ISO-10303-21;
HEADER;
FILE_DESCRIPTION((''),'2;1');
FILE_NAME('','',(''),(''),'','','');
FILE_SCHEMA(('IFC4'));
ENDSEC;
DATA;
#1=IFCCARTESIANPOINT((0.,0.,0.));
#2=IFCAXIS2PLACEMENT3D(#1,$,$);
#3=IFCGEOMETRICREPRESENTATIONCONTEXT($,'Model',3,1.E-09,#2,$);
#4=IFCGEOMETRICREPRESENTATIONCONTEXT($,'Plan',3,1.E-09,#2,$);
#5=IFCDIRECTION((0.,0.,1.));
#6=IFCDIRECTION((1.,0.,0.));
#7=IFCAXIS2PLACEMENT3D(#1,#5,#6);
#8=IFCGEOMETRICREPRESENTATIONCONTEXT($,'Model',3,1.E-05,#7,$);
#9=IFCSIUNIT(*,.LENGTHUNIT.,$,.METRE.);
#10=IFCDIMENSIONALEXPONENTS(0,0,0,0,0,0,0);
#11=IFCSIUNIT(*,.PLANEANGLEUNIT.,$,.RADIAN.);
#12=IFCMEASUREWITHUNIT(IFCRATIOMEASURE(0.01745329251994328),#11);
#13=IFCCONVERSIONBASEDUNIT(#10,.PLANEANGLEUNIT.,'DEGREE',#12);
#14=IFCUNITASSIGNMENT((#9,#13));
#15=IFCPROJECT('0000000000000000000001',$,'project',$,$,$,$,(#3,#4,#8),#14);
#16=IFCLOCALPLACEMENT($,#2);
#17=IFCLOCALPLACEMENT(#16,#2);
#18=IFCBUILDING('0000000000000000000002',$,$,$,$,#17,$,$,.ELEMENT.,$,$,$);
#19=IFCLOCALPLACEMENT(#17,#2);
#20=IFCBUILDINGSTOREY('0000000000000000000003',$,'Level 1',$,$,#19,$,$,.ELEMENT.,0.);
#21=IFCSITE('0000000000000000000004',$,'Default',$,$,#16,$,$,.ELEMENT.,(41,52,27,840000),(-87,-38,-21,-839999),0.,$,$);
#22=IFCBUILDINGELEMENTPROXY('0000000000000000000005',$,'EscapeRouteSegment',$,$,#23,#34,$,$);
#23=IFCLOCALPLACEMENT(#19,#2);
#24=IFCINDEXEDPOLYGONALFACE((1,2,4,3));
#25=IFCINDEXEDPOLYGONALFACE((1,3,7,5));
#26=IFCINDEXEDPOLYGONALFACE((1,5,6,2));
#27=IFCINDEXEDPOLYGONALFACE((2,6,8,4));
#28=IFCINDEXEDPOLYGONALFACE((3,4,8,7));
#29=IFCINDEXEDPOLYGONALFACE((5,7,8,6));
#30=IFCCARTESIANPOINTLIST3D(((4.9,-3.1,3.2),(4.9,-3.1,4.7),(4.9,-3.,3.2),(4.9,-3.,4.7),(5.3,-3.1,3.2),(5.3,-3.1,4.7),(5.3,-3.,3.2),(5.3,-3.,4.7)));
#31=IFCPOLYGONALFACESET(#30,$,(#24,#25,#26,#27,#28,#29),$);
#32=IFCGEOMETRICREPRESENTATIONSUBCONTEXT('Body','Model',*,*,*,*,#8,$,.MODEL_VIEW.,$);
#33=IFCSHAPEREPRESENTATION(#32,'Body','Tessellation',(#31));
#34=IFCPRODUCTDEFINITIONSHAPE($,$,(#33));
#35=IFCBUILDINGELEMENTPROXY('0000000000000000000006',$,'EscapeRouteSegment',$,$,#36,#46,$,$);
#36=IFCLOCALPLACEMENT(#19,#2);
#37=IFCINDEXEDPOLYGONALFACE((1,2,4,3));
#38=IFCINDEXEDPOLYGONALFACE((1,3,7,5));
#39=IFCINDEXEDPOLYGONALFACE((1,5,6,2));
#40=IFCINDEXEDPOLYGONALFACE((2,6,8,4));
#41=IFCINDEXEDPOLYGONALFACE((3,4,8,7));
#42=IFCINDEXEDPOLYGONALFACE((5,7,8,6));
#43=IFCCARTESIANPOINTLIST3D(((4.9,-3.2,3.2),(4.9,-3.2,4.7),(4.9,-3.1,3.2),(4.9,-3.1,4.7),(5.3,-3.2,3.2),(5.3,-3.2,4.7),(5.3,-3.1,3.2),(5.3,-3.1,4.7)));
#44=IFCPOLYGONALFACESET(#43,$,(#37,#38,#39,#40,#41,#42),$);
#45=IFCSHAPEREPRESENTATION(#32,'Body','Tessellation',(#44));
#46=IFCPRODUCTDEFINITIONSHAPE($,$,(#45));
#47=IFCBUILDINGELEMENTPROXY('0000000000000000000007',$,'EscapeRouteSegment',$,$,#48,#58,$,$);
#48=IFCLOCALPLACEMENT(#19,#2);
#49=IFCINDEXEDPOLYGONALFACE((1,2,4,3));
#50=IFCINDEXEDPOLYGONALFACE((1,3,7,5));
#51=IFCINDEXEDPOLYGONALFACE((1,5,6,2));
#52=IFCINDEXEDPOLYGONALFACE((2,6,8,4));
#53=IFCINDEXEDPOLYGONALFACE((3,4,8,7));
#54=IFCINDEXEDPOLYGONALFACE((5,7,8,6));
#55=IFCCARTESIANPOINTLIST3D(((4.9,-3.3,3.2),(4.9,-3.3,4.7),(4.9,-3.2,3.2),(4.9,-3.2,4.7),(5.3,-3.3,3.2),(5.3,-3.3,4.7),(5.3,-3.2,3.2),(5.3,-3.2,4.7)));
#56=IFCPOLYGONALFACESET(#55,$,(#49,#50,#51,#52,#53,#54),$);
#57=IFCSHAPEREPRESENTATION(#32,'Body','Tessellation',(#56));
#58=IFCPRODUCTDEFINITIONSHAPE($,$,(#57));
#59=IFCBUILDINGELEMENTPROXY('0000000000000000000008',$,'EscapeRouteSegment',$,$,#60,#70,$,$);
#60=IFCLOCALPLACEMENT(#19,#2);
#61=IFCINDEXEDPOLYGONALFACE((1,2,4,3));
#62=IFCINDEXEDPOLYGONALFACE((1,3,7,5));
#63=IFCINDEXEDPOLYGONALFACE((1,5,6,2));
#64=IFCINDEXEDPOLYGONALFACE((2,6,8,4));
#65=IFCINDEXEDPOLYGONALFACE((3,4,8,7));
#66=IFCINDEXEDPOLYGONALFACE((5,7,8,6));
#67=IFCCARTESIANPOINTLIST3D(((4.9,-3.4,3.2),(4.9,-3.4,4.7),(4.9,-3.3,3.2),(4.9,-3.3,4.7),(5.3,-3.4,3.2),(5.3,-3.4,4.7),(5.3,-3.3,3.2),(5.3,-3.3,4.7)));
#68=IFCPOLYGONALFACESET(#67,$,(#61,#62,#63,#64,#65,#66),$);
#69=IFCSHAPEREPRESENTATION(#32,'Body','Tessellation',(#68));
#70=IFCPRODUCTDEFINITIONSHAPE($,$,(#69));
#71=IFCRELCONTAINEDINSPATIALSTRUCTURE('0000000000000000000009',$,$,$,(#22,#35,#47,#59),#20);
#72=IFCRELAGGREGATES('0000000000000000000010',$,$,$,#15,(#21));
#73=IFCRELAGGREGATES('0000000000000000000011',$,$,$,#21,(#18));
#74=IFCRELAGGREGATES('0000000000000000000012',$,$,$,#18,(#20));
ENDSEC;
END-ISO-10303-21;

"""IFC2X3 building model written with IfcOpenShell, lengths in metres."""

from ifc_helpers import new_model, entity, si_unit, converted_unit, frame, origin, origin_with_axes, place, context, subcontext, project, spatial, polyline, outline, extrude, element, save


model = new_model("IFC2X3")

# Units and contexts
model_context_1 = context("Model", 3, precision=1e-09, world=origin())
plan_context = context("Plan", 3, precision=1e-09, world=origin())
model_context_2 = context("Model", 3, precision=1e-05, world=origin_with_axes())
body_context = subcontext(model_context_2, "Body", "Model", "MODEL_VIEW")
ifc_project = project(units=[si_unit("LENGTHUNIT", "METRE"), converted_unit("PLANEANGLEUNIT", "DEGREE", entity("IfcRatioMeasure", 0.01745329251994328), si_unit("PLANEANGLEUNIT", "RADIAN"), dimensions=[0, 0, 0, 0, 0, 0, 0])], contexts=[model_context_1, plan_context, model_context_2])

# Site, building, storey
site_placement = place(None, origin())
site = spatial("IfcSite", under=ifc_project, at=site_placement, Name="Default", CompositionType="ELEMENT", RefLatitude=(41, 52, 27, 840000), RefLongitude=(-87, -38, -21, -839999), RefElevation=0.0)
building_placement = place(site_placement, origin())
building = spatial("IfcBuilding", under=site, at=building_placement, CompositionType="ELEMENT")
storey_placement = place(building_placement, origin())
storey = spatial("IfcBuildingStorey", under=building, at=storey_placement, Name="Level 1", CompositionType="ELEMENT", Elevation=0.0)

# Building element proxies
for number, where, z_axis, x_axis, name in (
    (1, (5.1, -3.0, 3.2), (0.0, 0.0, 1.0), (0.0, -1.0, 0.0), "EscapeRouteSegment"),
):
    element("IfcBuildingElementProxy", number, at=place(storey_placement, frame(where, z_axis=z_axis, x_axis=x_axis)), inside=storey, Name=name, context=body_context, shape_type="SweptSolid", body=[
        extrude(outline(polyline([(0.0, -0.2), (0.0, 0.2), (0.1, 0.2), (0.1, -0.2), (0.0, -0.2)])), origin_with_axes(), (0.0, 0.0, 1.0), 1.5),
    ])
proxy_1_placement = place(storey_placement, frame((5.1, -3.1, 3.2), z_axis=(0.0, 0.0, 1.0), x_axis=(0.0, -1.0, 0.0)))
element("IfcBuildingElementProxy", 2, at=proxy_1_placement, inside=storey, Name="EscapeRouteSegment", context=body_context, shape_type="SweptSolid", body=[
    extrude(outline(polyline([(0.0, -0.2), (0.0, 0.2), (0.1, 0.2), (0.1, -0.2), (0.0, -0.2)])), origin_with_axes(), (0.0, 0.0, 1.0), 1.5),
])
proxy_2_placement = place(storey_placement, frame((5.1, -3.2, 3.2), z_axis=(0.0, 0.0, 1.0), x_axis=(0.0, -1.0, 0.0)))
element("IfcBuildingElementProxy", 3, at=proxy_2_placement, inside=storey, Name="EscapeRouteSegment", context=body_context, shape_type="SweptSolid", body=[
    extrude(outline(polyline([(0.0, -0.2), (0.0, 0.2), (0.1, 0.2), (0.1, -0.2), (0.0, -0.2)])), origin_with_axes(), (0.0, 0.0, 1.0), 1.5),
])
proxy_3_placement = place(storey_placement, frame((5.1, -3.3, 3.2), z_axis=(0.0, 0.0, 1.0), x_axis=(0.0, -1.0, 0.0)))
element("IfcBuildingElementProxy", 4, at=proxy_3_placement, inside=storey, Name="EscapeRouteSegment", context=body_context, shape_type="SweptSolid", body=[
    extrude(outline(polyline([(0.0, -0.2), (0.0, 0.2), (0.1, 0.2), (0.1, -0.2), (0.0, -0.2)])), origin_with_axes(), (0.0, 0.0, 1.0), 1.5),
])

save(model, "model.ifc")
